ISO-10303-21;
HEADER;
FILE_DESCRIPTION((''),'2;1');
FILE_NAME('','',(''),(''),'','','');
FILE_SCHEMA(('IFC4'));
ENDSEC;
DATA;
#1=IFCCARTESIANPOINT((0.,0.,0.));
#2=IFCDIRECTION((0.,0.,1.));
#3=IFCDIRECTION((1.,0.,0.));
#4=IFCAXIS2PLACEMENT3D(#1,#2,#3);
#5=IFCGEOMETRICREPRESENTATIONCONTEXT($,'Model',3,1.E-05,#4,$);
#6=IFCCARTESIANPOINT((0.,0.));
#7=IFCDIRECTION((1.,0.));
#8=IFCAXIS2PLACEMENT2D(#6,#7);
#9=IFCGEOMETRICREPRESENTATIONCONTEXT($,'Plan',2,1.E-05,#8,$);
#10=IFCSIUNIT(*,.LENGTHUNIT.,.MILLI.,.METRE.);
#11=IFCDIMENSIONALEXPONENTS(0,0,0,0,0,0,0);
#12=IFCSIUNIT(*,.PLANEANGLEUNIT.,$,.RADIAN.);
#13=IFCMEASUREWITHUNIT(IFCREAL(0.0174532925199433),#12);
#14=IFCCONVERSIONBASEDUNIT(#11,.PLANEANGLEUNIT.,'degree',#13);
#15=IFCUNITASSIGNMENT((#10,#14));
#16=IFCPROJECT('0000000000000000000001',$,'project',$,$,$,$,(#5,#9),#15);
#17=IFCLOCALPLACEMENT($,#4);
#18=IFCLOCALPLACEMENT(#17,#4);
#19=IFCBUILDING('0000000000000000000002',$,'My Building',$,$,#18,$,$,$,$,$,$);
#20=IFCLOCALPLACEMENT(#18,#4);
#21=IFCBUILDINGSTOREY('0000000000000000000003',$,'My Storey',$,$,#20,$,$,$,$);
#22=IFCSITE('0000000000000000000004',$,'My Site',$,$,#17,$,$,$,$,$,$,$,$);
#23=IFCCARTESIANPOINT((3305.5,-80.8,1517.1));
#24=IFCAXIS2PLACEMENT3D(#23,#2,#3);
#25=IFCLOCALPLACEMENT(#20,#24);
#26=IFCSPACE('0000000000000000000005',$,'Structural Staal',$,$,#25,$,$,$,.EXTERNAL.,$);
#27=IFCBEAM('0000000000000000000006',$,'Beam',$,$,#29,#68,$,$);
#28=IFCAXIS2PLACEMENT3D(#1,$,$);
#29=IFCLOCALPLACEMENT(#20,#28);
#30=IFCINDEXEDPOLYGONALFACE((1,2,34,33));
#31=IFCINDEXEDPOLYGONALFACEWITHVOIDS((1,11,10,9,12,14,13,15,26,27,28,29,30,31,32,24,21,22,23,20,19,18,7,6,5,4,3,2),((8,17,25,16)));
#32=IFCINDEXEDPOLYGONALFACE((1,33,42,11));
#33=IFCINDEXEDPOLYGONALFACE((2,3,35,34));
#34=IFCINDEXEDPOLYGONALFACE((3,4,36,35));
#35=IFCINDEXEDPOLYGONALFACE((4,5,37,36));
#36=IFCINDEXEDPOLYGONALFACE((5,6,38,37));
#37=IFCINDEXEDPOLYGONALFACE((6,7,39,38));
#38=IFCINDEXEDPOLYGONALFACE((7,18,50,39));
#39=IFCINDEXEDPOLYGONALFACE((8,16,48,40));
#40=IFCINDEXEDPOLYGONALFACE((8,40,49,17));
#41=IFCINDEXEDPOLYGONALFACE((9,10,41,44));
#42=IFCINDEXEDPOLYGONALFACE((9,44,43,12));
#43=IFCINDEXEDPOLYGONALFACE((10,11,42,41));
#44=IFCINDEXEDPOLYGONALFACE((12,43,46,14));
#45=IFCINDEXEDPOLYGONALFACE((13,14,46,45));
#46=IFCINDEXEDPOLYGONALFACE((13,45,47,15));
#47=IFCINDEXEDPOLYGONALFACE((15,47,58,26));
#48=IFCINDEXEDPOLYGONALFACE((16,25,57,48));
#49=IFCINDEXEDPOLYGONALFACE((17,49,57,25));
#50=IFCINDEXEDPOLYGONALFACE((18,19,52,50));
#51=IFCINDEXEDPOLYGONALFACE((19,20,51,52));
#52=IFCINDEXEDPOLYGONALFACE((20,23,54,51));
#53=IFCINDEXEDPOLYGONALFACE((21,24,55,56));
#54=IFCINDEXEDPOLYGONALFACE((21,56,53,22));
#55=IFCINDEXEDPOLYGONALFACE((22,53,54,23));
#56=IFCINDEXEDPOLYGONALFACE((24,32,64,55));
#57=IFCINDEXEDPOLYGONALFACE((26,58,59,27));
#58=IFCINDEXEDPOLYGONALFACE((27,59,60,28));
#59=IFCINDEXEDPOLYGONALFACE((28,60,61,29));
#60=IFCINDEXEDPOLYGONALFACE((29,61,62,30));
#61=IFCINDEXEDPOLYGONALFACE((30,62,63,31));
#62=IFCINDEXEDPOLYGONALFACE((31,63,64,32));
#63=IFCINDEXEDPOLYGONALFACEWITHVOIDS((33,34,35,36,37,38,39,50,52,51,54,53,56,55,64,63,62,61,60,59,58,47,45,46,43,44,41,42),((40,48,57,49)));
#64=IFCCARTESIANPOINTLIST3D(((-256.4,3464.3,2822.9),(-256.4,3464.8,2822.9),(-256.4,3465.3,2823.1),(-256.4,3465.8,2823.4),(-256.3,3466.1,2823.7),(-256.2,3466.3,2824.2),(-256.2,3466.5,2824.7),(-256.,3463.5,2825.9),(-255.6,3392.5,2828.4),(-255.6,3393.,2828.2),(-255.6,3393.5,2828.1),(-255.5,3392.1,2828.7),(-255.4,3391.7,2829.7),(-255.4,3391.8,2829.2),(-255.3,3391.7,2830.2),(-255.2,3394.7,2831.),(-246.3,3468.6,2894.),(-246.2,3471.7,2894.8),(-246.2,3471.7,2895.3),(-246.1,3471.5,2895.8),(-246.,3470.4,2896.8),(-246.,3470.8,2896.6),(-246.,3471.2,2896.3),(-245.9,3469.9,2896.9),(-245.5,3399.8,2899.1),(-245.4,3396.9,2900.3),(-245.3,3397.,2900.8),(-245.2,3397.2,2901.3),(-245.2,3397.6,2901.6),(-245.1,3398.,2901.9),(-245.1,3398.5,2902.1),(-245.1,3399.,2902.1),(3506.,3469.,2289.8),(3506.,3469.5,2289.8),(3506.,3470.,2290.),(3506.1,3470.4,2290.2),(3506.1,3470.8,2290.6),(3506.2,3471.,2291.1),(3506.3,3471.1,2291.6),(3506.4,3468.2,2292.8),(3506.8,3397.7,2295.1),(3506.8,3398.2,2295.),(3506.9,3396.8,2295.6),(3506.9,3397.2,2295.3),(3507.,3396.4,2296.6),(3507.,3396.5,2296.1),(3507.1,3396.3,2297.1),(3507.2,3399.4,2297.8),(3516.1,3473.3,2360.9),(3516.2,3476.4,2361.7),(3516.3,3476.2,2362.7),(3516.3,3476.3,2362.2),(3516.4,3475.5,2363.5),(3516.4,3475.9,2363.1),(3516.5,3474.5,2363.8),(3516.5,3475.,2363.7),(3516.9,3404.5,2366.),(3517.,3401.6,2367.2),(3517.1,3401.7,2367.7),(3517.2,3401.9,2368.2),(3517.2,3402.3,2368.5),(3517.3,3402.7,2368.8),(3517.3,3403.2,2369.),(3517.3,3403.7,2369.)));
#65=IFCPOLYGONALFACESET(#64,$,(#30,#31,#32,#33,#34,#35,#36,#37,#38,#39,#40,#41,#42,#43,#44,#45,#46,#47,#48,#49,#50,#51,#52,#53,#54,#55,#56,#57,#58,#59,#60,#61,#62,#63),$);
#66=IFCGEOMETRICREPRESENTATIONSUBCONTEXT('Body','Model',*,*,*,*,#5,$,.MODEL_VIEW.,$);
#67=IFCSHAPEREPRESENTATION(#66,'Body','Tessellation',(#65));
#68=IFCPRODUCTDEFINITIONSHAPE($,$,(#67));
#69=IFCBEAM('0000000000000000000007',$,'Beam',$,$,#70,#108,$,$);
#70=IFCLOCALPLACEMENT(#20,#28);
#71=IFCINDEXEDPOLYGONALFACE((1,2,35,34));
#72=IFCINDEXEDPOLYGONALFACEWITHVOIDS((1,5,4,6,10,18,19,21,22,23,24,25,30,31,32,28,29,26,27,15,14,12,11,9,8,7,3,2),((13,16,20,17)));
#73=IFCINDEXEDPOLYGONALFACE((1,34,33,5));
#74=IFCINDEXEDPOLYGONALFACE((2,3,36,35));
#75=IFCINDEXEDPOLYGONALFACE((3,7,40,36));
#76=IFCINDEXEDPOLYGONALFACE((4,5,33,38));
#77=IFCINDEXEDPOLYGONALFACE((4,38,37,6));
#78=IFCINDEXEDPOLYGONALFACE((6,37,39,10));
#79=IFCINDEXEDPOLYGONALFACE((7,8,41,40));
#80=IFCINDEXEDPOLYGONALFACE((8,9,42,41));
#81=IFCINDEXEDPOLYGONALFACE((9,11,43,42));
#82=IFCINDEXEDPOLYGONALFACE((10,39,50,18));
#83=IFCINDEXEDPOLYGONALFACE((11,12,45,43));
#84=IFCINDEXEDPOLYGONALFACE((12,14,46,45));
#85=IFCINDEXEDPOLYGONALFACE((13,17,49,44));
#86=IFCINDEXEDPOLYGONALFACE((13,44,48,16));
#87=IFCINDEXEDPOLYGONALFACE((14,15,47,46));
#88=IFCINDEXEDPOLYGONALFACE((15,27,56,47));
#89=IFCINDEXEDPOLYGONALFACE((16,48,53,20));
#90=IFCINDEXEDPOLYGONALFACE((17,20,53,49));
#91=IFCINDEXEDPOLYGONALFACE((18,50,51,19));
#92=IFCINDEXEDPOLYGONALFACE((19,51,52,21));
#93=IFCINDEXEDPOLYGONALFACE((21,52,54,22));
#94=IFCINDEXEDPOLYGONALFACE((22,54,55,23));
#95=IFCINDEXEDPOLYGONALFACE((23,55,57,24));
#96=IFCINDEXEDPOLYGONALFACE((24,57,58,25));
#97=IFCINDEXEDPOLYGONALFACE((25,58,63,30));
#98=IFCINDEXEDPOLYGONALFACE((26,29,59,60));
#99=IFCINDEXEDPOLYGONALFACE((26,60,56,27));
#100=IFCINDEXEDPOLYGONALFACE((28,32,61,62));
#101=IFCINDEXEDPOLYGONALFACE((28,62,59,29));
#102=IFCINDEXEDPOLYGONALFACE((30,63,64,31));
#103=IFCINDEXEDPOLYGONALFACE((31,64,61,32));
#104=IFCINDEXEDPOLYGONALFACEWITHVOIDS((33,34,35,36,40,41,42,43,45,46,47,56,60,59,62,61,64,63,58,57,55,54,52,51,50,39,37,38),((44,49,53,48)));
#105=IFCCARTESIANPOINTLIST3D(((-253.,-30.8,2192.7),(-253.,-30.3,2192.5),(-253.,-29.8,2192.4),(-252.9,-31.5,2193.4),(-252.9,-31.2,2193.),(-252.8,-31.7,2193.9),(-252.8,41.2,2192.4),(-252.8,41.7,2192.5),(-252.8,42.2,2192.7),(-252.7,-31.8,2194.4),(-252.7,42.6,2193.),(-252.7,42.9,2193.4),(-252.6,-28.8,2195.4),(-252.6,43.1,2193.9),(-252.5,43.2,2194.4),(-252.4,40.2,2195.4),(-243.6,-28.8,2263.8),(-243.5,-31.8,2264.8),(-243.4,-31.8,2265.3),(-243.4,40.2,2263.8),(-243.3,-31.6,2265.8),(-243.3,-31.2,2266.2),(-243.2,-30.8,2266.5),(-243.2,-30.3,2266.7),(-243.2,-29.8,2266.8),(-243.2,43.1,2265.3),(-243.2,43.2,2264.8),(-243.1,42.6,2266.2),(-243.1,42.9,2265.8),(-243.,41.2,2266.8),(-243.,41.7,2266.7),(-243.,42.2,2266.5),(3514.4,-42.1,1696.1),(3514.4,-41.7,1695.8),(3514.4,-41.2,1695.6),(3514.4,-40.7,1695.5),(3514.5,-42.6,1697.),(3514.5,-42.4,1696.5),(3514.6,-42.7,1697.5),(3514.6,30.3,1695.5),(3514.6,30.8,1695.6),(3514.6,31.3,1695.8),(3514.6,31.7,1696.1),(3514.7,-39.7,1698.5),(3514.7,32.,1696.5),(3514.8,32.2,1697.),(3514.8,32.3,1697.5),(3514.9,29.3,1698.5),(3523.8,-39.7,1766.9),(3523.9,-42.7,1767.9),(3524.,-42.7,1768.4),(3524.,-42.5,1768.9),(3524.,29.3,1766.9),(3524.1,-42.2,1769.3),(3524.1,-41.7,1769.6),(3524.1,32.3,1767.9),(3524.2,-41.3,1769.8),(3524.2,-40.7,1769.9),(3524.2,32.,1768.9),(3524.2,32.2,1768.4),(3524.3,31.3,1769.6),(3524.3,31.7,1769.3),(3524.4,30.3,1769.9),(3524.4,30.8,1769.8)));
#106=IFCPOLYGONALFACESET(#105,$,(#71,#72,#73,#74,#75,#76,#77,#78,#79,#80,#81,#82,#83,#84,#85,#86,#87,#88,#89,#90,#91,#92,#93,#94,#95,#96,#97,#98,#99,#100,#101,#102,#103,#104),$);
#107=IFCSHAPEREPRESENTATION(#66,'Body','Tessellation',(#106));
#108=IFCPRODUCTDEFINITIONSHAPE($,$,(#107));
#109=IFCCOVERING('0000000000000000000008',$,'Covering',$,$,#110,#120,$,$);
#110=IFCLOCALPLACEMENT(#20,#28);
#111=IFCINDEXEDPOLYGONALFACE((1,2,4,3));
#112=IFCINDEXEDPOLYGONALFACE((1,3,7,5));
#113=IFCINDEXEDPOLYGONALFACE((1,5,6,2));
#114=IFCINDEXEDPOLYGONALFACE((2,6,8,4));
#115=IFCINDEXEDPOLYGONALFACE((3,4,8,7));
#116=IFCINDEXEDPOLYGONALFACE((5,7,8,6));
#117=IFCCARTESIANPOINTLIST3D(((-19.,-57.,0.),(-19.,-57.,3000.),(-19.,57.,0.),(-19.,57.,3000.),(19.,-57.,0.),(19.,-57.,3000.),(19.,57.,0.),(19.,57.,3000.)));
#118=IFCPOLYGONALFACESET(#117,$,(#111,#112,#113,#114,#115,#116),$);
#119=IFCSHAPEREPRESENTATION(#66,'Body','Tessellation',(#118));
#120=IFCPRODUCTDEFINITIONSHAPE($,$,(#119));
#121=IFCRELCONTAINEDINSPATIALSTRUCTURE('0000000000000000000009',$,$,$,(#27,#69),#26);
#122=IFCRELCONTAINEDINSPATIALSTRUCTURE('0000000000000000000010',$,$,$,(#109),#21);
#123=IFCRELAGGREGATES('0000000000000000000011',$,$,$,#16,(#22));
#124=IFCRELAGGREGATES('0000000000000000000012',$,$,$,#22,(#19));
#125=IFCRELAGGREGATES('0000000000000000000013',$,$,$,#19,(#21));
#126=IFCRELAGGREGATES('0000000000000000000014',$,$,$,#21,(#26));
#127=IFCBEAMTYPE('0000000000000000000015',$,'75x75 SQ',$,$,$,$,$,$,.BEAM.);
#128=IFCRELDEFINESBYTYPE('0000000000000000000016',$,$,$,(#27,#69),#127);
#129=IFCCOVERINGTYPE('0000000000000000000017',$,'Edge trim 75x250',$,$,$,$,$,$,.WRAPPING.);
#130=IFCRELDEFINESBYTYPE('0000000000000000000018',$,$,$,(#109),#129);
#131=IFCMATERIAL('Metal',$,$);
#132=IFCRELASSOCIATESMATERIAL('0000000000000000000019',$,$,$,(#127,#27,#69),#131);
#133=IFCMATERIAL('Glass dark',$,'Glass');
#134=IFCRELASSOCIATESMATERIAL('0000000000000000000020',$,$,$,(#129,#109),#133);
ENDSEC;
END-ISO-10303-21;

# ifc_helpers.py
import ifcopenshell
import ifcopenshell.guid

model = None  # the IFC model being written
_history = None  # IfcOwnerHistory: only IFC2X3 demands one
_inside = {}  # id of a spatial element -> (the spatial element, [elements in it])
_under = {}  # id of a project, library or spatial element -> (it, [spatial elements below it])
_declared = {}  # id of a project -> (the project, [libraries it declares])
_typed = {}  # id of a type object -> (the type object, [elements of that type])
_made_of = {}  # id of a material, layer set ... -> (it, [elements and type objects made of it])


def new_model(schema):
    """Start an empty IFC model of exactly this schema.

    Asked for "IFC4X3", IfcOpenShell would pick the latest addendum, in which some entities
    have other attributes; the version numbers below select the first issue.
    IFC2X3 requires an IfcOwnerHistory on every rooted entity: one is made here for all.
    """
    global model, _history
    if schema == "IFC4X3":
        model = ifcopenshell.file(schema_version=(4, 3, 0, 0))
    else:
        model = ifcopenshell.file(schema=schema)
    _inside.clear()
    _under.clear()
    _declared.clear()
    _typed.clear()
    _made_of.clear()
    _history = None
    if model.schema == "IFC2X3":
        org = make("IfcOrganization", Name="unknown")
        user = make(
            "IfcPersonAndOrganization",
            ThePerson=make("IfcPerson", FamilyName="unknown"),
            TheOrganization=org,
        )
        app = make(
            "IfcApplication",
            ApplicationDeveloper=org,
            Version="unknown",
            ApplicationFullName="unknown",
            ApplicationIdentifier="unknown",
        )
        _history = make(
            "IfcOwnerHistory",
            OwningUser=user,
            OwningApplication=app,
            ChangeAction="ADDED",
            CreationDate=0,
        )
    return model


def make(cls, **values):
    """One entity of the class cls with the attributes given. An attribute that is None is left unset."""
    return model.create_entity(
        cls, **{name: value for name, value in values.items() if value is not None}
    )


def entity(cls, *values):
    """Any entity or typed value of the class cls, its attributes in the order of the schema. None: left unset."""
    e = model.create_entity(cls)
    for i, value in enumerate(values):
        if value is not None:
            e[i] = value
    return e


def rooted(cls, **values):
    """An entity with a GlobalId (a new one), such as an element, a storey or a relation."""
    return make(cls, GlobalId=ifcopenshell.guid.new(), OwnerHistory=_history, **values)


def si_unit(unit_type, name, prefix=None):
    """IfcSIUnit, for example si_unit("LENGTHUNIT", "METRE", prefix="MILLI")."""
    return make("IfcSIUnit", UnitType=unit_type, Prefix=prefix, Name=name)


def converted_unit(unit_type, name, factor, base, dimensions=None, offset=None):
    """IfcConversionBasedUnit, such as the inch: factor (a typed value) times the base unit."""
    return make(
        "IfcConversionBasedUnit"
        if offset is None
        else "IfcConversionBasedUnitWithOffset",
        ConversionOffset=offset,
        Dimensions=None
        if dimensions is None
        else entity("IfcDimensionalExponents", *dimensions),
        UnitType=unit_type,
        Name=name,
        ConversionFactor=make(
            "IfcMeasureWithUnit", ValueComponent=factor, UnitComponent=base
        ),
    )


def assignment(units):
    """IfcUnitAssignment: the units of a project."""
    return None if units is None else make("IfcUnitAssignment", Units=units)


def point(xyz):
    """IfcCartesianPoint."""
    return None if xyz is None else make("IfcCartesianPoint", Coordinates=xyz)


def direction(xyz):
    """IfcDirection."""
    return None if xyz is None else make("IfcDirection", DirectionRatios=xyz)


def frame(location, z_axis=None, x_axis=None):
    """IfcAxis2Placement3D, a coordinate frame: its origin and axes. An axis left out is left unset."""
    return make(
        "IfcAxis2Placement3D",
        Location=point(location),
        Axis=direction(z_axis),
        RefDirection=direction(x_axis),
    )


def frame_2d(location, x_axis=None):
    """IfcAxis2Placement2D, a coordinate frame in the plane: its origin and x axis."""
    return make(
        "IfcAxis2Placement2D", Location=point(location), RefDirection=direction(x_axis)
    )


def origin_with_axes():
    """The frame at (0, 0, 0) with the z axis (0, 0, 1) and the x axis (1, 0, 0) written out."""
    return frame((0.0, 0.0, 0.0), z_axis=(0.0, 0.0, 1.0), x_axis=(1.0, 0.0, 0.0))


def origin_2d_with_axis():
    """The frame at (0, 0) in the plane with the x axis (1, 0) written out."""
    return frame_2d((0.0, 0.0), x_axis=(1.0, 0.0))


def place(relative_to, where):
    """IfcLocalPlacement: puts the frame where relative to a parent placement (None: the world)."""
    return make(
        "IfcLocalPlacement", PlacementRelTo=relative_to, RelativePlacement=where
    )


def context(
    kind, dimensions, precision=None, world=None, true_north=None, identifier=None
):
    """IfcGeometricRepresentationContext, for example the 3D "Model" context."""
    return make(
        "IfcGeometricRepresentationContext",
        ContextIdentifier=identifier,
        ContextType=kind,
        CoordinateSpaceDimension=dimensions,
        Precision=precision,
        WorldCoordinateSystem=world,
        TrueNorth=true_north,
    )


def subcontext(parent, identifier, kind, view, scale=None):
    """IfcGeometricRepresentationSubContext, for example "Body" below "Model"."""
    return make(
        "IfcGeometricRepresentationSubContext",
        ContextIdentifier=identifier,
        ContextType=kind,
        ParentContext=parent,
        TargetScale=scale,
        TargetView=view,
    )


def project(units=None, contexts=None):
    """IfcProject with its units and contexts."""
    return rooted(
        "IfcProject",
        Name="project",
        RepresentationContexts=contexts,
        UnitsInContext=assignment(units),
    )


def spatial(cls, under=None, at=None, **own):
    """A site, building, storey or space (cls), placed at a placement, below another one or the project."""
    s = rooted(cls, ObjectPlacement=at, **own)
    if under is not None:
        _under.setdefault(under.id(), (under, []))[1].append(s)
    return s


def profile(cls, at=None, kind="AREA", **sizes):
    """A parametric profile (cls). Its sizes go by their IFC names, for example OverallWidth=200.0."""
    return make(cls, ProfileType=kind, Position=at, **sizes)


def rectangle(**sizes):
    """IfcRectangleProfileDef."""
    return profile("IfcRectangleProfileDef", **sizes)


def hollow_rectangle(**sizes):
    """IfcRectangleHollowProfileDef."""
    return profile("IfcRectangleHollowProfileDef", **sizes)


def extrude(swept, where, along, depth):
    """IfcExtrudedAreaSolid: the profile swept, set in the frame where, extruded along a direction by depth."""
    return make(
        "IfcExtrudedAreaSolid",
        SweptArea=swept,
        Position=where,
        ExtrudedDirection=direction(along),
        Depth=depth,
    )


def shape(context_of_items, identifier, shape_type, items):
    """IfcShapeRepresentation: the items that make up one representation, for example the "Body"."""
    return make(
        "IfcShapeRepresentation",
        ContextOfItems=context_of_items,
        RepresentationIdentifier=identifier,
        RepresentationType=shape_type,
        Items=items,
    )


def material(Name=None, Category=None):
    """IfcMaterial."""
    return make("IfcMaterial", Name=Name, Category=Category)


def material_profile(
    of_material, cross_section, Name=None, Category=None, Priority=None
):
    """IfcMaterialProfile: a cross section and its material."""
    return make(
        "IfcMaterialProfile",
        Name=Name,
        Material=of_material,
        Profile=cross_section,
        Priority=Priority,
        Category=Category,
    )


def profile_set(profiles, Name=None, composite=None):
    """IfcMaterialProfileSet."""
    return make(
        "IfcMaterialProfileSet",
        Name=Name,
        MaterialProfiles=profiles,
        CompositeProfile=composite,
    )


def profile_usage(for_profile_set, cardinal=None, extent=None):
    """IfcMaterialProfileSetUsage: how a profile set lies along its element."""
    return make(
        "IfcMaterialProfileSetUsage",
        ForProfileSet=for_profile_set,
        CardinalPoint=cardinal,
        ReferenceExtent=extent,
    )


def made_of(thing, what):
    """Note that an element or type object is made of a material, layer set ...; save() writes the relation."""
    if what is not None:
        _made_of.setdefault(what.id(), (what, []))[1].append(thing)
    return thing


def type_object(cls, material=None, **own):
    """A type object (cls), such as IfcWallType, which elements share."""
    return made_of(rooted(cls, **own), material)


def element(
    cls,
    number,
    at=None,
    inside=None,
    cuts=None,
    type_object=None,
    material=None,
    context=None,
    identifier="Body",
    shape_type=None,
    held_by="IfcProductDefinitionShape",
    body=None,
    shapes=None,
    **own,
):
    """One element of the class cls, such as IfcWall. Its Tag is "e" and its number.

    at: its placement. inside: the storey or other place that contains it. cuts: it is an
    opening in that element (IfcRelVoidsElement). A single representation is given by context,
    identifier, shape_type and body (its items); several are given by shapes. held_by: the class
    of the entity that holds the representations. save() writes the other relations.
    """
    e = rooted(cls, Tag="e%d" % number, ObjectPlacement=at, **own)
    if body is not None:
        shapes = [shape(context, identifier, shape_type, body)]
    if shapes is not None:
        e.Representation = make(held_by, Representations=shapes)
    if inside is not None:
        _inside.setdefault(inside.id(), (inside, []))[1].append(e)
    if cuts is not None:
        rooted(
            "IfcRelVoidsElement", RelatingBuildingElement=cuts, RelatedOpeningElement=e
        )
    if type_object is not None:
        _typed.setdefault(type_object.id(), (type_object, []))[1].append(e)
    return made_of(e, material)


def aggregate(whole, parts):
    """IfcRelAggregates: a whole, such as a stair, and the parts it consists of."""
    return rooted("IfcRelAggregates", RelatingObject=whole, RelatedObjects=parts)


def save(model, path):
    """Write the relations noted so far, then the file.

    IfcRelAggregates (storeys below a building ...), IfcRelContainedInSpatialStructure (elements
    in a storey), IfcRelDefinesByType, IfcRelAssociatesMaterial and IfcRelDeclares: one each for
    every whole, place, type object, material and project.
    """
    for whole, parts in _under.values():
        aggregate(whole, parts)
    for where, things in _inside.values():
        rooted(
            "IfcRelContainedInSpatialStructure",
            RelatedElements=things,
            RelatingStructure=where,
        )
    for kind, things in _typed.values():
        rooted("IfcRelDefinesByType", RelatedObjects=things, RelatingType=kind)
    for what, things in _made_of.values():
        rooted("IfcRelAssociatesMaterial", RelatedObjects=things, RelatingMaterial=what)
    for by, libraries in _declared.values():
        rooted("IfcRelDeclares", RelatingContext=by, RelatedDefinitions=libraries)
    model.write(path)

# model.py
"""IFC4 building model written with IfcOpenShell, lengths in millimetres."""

from ifc_helpers import new_model, entity, si_unit, converted_unit, frame, origin_with_axes, origin_2d_with_axis, place, context, subcontext, project, spatial, rectangle, hollow_rectangle, extrude, material, material_profile, profile_set, profile_usage, type_object, element, save


model = new_model("IFC4")

# Units and contexts
model_context = context("Model", 3, precision=1e-05, world=origin_with_axes())
plan_context = context("Plan", 2, precision=1e-05, world=origin_2d_with_axis())
body_context = subcontext(model_context, "Body", "Model", "MODEL_VIEW")
ifc_project = project(units=[si_unit("LENGTHUNIT", "METRE", prefix="MILLI"), converted_unit("PLANEANGLEUNIT", "degree", entity("IfcReal", 0.0174532925199433), si_unit("PLANEANGLEUNIT", "RADIAN"), dimensions=[0, 0, 0, 0, 0, 0, 0])], contexts=[model_context, plan_context])

# Site, building, storey
site_placement = place(None, origin_with_axes())
site = spatial("IfcSite", under=ifc_project, at=site_placement, Name="My Site")
building_placement = place(site_placement, origin_with_axes())
building = spatial("IfcBuilding", under=site, at=building_placement, Name="My Building")
storey_placement = place(building_placement, origin_with_axes())
storey = spatial("IfcBuildingStorey", under=building, at=storey_placement, Name="My Storey")

# Shared definitions
space_1_placement = place(storey_placement, frame((3305.5, -80.8, 1517.1), z_axis=(0.0, 0.0, 1.0), x_axis=(1.0, 0.0, 0.0)))
space_1 = spatial("IfcSpace", under=storey, at=space_1_placement, Name="Structural Staal", PredefinedType="EXTERNAL")

# Shared definitions
ifc_material_1 = material(Name="Metal")

# Beams
ifc_material_profile_1 = material_profile(ifc_material_1, hollow_rectangle(XDim=75.0, YDim=75.0, WallThickness=3.0, OuterFilletRadius=2.0))
ifc_profile_set_1 = profile_set([ifc_material_profile_1])
ifc_profile_usage_1 = profile_usage(ifc_profile_set_1, cardinal=5)
beam_type_1 = type_object("IfcBeamType", Name="75x75 SQ", PredefinedType="BEAM", material=ifc_profile_set_1)
beam_1_placement = place(space_1_placement, frame((-3556.2, 3512.5, 1345.4), z_axis=(0.99011, 0.001228, -0.140291), x_axis=(-0.011586, 0.997262, -0.073036)))
element("IfcBeam", 1, at=beam_1_placement, inside=space_1, type_object=beam_type_1, material=ifc_profile_usage_1, Name="Beam", context=body_context, shape_type="SweptSolid", body=[
    extrude(hollow_rectangle(XDim=75.0, YDim=75.0, WallThickness=3.0, OuterFilletRadius=2.0), origin_with_axes(), (0.0, 0.0, 1.0), 3800.0),
])
ifc_profile_usage_2 = profile_usage(ifc_profile_set_1, cardinal=5)
beam_2_placement = place(space_1_placement, frame((-3553.4, 86.5, 712.5), z_axis=(0.991409, -0.002872, -0.130766), x_axis=(0.002897, 0.999996, 0.0)))
element("IfcBeam", 2, at=beam_2_placement, inside=space_1, type_object=beam_type_1, material=ifc_profile_usage_2, Name="Beam", context=body_context, shape_type="SweptSolid", body=[
    extrude(hollow_rectangle(XDim=75.0, YDim=75.0, WallThickness=3.0, OuterFilletRadius=2.0), origin_with_axes(), (0.0, 0.0, 1.0), 3800.0),
])

# Covering
ifc_material_2 = material(Name="Glass dark", Category="Glass")
ifc_material_profile_2 = material_profile(ifc_material_2, rectangle(XDim=38.0, YDim=114.0))
ifc_profile_set_2 = profile_set([ifc_material_profile_2])
ifc_profile_usage_3 = profile_usage(ifc_profile_set_2, cardinal=5)
covering_type = type_object("IfcCoveringType", Name="Edge trim 75x250", PredefinedType="WRAPPING", material=ifc_profile_set_2)
covering_placement = place(storey_placement, origin_with_axes())
element("IfcCovering", 3, at=covering_placement, inside=storey, type_object=covering_type, material=ifc_profile_usage_3, Name="Covering", context=body_context, shape_type="SweptSolid", body=[
    extrude(rectangle(XDim=38.0, YDim=114.0), origin_with_axes(), (0.0, 0.0, 1.0), 3000.0),
])

save(model, "model.ifc")
